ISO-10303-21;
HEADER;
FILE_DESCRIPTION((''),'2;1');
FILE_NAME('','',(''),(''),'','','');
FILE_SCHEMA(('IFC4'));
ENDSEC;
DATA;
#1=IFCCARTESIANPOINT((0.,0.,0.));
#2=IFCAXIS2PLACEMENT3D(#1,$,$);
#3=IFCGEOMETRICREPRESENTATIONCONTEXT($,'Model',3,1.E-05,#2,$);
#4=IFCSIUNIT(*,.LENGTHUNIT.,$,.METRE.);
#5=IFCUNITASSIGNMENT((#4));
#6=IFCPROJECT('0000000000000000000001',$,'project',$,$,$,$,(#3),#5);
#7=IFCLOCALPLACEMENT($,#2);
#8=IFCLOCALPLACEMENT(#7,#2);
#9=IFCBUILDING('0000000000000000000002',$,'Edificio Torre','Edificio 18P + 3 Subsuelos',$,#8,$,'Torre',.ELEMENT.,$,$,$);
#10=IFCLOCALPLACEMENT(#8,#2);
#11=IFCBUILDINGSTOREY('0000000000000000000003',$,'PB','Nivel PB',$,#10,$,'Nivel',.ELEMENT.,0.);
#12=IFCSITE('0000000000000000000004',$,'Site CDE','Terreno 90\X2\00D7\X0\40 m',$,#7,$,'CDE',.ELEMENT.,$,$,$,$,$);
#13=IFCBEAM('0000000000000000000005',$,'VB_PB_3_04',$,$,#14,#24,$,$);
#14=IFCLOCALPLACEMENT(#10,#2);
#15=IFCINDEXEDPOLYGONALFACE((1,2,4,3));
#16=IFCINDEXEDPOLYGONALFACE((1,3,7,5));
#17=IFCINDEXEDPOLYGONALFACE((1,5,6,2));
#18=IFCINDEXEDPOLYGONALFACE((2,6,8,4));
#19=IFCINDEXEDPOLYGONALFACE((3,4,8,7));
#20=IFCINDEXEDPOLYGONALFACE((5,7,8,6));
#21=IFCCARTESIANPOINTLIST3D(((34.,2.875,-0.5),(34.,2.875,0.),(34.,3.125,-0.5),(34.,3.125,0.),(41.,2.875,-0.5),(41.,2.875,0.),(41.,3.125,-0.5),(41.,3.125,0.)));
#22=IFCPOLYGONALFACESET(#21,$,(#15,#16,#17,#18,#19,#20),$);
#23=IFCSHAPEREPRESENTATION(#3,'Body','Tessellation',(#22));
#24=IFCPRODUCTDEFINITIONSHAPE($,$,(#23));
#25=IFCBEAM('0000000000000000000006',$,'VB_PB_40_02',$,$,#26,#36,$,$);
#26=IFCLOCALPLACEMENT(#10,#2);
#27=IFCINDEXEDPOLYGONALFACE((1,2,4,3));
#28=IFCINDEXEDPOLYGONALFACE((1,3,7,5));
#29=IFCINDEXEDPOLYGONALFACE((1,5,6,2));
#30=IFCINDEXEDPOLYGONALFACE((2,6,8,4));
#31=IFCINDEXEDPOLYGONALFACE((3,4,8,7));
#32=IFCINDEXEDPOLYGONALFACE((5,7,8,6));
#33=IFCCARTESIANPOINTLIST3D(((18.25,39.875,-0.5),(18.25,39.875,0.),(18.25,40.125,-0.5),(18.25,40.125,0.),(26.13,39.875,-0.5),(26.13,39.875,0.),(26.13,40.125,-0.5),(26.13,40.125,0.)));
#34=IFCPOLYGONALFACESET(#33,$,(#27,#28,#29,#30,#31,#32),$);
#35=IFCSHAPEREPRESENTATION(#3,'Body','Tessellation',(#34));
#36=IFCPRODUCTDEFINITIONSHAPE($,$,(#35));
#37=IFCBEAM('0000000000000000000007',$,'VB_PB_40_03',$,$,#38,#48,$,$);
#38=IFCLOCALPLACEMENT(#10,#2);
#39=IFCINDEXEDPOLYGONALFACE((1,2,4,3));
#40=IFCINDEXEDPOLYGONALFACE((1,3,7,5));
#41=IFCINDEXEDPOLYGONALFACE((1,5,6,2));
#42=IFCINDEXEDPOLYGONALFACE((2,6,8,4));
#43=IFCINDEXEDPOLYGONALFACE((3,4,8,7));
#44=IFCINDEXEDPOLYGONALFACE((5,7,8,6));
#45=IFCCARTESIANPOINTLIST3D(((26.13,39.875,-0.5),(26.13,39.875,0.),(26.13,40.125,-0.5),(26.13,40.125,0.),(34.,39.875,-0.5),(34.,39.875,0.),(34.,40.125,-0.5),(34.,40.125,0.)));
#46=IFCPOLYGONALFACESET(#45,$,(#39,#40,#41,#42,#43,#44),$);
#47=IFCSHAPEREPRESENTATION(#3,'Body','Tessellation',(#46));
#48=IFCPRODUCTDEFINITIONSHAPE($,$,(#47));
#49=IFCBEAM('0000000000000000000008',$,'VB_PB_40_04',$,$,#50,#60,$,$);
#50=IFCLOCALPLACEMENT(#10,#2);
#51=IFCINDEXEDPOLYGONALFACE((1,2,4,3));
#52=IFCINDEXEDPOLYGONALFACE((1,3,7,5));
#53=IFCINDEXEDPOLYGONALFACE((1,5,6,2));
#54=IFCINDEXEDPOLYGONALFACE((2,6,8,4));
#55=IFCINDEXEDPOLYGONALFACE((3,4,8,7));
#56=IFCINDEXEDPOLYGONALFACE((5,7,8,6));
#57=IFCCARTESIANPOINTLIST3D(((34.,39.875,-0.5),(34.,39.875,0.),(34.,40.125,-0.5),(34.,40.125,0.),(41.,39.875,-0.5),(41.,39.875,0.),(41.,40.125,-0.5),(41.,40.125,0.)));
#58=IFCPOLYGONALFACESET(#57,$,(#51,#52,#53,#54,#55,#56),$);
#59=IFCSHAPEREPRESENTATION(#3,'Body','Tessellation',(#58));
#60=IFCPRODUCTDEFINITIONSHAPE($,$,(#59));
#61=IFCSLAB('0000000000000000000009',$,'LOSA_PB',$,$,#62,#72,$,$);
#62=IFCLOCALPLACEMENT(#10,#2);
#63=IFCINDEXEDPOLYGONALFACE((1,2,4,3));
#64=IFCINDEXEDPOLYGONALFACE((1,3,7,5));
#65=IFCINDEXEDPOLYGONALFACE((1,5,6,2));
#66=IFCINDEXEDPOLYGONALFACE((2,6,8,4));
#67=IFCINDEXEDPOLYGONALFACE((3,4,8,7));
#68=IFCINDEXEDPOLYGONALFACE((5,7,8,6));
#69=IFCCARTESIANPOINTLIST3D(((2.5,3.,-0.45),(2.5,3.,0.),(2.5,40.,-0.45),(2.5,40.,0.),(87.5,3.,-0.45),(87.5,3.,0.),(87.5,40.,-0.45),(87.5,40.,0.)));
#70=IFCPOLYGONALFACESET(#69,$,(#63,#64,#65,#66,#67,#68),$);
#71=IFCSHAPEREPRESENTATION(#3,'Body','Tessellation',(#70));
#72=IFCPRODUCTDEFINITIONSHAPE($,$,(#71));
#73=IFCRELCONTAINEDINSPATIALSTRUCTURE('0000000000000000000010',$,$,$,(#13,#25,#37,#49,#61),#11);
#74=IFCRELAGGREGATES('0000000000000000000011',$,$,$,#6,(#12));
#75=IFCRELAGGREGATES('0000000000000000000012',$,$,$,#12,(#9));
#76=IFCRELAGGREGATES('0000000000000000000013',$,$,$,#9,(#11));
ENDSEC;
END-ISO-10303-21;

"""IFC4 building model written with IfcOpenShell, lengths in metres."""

from ifc_helpers import new_model, si_unit, frame, origin, origin_2d, place, context, project, spatial, rectangle, extrude, element, save


model = new_model("IFC4")

# Units and contexts
model_context = context("Model", 3, precision=1e-05, world=origin())
ifc_project = project(units=[si_unit("LENGTHUNIT", "METRE")], contexts=[model_context])

# Site, building, storey
site_placement = place(None, origin())
site = spatial("IfcSite", under=ifc_project, at=site_placement, Name="Site CDE", Description="Terreno 90×40 m", LongName="CDE", CompositionType="ELEMENT")
building_placement = place(site_placement, origin())
building = spatial("IfcBuilding", under=site, at=building_placement, Name="Edificio Torre", Description="Edificio 18P + 3 Subsuelos", LongName="Torre", CompositionType="ELEMENT")
storey_placement = place(building_placement, origin())
storey = spatial("IfcBuildingStorey", under=building, at=storey_placement, Name="PB", Description="Nivel PB", LongName="Nivel", CompositionType="ELEMENT", Elevation=0.0)

# Beams
beam_1_placement = place(storey_placement, frame((37.5, 3.0, -0.5)))
element("IfcBeam", 1, at=beam_1_placement, inside=storey, Name="VB_PB_3_04", context=model_context, shape_type="SweptSolid", body=[
    extrude(rectangle(XDim=7.0, YDim=0.25, at=origin_2d()), origin(), (0.0, 0.0, 1.0), 0.5),
])
beam_2_placement = place(storey_placement, frame((22.19, 40.0, -0.5)))
element("IfcBeam", 2, at=beam_2_placement, inside=storey, Name="VB_PB_40_02", context=model_context, shape_type="SweptSolid", body=[
    extrude(rectangle(XDim=7.88, YDim=0.25, at=origin_2d()), origin(), (0.0, 0.0, 1.0), 0.5),
])
beam_3_placement = place(storey_placement, frame((30.065, 40.0, -0.5)))
element("IfcBeam", 3, at=beam_3_placement, inside=storey, Name="VB_PB_40_03", context=model_context, shape_type="SweptSolid", body=[
    extrude(rectangle(XDim=7.87, YDim=0.25, at=origin_2d()), origin(), (0.0, 0.0, 1.0), 0.5),
])
beam_4_placement = place(storey_placement, frame((37.5, 40.0, -0.5)))
element("IfcBeam", 4, at=beam_4_placement, inside=storey, Name="VB_PB_40_04", context=model_context, shape_type="SweptSolid", body=[
    extrude(rectangle(XDim=7.0, YDim=0.25, at=origin_2d()), origin(), (0.0, 0.0, 1.0), 0.5),
])

# Slab
slab_placement = place(storey_placement, frame((45.0, 21.5, -0.45)))
element("IfcSlab", 5, at=slab_placement, inside=storey, Name="LOSA_PB", context=model_context, shape_type="SweptSolid", body=[
    extrude(rectangle(XDim=85.0, YDim=37.0, at=origin_2d()), origin(), (0.0, 0.0, 1.0), 0.45),
])

save(model, "model.ifc")
